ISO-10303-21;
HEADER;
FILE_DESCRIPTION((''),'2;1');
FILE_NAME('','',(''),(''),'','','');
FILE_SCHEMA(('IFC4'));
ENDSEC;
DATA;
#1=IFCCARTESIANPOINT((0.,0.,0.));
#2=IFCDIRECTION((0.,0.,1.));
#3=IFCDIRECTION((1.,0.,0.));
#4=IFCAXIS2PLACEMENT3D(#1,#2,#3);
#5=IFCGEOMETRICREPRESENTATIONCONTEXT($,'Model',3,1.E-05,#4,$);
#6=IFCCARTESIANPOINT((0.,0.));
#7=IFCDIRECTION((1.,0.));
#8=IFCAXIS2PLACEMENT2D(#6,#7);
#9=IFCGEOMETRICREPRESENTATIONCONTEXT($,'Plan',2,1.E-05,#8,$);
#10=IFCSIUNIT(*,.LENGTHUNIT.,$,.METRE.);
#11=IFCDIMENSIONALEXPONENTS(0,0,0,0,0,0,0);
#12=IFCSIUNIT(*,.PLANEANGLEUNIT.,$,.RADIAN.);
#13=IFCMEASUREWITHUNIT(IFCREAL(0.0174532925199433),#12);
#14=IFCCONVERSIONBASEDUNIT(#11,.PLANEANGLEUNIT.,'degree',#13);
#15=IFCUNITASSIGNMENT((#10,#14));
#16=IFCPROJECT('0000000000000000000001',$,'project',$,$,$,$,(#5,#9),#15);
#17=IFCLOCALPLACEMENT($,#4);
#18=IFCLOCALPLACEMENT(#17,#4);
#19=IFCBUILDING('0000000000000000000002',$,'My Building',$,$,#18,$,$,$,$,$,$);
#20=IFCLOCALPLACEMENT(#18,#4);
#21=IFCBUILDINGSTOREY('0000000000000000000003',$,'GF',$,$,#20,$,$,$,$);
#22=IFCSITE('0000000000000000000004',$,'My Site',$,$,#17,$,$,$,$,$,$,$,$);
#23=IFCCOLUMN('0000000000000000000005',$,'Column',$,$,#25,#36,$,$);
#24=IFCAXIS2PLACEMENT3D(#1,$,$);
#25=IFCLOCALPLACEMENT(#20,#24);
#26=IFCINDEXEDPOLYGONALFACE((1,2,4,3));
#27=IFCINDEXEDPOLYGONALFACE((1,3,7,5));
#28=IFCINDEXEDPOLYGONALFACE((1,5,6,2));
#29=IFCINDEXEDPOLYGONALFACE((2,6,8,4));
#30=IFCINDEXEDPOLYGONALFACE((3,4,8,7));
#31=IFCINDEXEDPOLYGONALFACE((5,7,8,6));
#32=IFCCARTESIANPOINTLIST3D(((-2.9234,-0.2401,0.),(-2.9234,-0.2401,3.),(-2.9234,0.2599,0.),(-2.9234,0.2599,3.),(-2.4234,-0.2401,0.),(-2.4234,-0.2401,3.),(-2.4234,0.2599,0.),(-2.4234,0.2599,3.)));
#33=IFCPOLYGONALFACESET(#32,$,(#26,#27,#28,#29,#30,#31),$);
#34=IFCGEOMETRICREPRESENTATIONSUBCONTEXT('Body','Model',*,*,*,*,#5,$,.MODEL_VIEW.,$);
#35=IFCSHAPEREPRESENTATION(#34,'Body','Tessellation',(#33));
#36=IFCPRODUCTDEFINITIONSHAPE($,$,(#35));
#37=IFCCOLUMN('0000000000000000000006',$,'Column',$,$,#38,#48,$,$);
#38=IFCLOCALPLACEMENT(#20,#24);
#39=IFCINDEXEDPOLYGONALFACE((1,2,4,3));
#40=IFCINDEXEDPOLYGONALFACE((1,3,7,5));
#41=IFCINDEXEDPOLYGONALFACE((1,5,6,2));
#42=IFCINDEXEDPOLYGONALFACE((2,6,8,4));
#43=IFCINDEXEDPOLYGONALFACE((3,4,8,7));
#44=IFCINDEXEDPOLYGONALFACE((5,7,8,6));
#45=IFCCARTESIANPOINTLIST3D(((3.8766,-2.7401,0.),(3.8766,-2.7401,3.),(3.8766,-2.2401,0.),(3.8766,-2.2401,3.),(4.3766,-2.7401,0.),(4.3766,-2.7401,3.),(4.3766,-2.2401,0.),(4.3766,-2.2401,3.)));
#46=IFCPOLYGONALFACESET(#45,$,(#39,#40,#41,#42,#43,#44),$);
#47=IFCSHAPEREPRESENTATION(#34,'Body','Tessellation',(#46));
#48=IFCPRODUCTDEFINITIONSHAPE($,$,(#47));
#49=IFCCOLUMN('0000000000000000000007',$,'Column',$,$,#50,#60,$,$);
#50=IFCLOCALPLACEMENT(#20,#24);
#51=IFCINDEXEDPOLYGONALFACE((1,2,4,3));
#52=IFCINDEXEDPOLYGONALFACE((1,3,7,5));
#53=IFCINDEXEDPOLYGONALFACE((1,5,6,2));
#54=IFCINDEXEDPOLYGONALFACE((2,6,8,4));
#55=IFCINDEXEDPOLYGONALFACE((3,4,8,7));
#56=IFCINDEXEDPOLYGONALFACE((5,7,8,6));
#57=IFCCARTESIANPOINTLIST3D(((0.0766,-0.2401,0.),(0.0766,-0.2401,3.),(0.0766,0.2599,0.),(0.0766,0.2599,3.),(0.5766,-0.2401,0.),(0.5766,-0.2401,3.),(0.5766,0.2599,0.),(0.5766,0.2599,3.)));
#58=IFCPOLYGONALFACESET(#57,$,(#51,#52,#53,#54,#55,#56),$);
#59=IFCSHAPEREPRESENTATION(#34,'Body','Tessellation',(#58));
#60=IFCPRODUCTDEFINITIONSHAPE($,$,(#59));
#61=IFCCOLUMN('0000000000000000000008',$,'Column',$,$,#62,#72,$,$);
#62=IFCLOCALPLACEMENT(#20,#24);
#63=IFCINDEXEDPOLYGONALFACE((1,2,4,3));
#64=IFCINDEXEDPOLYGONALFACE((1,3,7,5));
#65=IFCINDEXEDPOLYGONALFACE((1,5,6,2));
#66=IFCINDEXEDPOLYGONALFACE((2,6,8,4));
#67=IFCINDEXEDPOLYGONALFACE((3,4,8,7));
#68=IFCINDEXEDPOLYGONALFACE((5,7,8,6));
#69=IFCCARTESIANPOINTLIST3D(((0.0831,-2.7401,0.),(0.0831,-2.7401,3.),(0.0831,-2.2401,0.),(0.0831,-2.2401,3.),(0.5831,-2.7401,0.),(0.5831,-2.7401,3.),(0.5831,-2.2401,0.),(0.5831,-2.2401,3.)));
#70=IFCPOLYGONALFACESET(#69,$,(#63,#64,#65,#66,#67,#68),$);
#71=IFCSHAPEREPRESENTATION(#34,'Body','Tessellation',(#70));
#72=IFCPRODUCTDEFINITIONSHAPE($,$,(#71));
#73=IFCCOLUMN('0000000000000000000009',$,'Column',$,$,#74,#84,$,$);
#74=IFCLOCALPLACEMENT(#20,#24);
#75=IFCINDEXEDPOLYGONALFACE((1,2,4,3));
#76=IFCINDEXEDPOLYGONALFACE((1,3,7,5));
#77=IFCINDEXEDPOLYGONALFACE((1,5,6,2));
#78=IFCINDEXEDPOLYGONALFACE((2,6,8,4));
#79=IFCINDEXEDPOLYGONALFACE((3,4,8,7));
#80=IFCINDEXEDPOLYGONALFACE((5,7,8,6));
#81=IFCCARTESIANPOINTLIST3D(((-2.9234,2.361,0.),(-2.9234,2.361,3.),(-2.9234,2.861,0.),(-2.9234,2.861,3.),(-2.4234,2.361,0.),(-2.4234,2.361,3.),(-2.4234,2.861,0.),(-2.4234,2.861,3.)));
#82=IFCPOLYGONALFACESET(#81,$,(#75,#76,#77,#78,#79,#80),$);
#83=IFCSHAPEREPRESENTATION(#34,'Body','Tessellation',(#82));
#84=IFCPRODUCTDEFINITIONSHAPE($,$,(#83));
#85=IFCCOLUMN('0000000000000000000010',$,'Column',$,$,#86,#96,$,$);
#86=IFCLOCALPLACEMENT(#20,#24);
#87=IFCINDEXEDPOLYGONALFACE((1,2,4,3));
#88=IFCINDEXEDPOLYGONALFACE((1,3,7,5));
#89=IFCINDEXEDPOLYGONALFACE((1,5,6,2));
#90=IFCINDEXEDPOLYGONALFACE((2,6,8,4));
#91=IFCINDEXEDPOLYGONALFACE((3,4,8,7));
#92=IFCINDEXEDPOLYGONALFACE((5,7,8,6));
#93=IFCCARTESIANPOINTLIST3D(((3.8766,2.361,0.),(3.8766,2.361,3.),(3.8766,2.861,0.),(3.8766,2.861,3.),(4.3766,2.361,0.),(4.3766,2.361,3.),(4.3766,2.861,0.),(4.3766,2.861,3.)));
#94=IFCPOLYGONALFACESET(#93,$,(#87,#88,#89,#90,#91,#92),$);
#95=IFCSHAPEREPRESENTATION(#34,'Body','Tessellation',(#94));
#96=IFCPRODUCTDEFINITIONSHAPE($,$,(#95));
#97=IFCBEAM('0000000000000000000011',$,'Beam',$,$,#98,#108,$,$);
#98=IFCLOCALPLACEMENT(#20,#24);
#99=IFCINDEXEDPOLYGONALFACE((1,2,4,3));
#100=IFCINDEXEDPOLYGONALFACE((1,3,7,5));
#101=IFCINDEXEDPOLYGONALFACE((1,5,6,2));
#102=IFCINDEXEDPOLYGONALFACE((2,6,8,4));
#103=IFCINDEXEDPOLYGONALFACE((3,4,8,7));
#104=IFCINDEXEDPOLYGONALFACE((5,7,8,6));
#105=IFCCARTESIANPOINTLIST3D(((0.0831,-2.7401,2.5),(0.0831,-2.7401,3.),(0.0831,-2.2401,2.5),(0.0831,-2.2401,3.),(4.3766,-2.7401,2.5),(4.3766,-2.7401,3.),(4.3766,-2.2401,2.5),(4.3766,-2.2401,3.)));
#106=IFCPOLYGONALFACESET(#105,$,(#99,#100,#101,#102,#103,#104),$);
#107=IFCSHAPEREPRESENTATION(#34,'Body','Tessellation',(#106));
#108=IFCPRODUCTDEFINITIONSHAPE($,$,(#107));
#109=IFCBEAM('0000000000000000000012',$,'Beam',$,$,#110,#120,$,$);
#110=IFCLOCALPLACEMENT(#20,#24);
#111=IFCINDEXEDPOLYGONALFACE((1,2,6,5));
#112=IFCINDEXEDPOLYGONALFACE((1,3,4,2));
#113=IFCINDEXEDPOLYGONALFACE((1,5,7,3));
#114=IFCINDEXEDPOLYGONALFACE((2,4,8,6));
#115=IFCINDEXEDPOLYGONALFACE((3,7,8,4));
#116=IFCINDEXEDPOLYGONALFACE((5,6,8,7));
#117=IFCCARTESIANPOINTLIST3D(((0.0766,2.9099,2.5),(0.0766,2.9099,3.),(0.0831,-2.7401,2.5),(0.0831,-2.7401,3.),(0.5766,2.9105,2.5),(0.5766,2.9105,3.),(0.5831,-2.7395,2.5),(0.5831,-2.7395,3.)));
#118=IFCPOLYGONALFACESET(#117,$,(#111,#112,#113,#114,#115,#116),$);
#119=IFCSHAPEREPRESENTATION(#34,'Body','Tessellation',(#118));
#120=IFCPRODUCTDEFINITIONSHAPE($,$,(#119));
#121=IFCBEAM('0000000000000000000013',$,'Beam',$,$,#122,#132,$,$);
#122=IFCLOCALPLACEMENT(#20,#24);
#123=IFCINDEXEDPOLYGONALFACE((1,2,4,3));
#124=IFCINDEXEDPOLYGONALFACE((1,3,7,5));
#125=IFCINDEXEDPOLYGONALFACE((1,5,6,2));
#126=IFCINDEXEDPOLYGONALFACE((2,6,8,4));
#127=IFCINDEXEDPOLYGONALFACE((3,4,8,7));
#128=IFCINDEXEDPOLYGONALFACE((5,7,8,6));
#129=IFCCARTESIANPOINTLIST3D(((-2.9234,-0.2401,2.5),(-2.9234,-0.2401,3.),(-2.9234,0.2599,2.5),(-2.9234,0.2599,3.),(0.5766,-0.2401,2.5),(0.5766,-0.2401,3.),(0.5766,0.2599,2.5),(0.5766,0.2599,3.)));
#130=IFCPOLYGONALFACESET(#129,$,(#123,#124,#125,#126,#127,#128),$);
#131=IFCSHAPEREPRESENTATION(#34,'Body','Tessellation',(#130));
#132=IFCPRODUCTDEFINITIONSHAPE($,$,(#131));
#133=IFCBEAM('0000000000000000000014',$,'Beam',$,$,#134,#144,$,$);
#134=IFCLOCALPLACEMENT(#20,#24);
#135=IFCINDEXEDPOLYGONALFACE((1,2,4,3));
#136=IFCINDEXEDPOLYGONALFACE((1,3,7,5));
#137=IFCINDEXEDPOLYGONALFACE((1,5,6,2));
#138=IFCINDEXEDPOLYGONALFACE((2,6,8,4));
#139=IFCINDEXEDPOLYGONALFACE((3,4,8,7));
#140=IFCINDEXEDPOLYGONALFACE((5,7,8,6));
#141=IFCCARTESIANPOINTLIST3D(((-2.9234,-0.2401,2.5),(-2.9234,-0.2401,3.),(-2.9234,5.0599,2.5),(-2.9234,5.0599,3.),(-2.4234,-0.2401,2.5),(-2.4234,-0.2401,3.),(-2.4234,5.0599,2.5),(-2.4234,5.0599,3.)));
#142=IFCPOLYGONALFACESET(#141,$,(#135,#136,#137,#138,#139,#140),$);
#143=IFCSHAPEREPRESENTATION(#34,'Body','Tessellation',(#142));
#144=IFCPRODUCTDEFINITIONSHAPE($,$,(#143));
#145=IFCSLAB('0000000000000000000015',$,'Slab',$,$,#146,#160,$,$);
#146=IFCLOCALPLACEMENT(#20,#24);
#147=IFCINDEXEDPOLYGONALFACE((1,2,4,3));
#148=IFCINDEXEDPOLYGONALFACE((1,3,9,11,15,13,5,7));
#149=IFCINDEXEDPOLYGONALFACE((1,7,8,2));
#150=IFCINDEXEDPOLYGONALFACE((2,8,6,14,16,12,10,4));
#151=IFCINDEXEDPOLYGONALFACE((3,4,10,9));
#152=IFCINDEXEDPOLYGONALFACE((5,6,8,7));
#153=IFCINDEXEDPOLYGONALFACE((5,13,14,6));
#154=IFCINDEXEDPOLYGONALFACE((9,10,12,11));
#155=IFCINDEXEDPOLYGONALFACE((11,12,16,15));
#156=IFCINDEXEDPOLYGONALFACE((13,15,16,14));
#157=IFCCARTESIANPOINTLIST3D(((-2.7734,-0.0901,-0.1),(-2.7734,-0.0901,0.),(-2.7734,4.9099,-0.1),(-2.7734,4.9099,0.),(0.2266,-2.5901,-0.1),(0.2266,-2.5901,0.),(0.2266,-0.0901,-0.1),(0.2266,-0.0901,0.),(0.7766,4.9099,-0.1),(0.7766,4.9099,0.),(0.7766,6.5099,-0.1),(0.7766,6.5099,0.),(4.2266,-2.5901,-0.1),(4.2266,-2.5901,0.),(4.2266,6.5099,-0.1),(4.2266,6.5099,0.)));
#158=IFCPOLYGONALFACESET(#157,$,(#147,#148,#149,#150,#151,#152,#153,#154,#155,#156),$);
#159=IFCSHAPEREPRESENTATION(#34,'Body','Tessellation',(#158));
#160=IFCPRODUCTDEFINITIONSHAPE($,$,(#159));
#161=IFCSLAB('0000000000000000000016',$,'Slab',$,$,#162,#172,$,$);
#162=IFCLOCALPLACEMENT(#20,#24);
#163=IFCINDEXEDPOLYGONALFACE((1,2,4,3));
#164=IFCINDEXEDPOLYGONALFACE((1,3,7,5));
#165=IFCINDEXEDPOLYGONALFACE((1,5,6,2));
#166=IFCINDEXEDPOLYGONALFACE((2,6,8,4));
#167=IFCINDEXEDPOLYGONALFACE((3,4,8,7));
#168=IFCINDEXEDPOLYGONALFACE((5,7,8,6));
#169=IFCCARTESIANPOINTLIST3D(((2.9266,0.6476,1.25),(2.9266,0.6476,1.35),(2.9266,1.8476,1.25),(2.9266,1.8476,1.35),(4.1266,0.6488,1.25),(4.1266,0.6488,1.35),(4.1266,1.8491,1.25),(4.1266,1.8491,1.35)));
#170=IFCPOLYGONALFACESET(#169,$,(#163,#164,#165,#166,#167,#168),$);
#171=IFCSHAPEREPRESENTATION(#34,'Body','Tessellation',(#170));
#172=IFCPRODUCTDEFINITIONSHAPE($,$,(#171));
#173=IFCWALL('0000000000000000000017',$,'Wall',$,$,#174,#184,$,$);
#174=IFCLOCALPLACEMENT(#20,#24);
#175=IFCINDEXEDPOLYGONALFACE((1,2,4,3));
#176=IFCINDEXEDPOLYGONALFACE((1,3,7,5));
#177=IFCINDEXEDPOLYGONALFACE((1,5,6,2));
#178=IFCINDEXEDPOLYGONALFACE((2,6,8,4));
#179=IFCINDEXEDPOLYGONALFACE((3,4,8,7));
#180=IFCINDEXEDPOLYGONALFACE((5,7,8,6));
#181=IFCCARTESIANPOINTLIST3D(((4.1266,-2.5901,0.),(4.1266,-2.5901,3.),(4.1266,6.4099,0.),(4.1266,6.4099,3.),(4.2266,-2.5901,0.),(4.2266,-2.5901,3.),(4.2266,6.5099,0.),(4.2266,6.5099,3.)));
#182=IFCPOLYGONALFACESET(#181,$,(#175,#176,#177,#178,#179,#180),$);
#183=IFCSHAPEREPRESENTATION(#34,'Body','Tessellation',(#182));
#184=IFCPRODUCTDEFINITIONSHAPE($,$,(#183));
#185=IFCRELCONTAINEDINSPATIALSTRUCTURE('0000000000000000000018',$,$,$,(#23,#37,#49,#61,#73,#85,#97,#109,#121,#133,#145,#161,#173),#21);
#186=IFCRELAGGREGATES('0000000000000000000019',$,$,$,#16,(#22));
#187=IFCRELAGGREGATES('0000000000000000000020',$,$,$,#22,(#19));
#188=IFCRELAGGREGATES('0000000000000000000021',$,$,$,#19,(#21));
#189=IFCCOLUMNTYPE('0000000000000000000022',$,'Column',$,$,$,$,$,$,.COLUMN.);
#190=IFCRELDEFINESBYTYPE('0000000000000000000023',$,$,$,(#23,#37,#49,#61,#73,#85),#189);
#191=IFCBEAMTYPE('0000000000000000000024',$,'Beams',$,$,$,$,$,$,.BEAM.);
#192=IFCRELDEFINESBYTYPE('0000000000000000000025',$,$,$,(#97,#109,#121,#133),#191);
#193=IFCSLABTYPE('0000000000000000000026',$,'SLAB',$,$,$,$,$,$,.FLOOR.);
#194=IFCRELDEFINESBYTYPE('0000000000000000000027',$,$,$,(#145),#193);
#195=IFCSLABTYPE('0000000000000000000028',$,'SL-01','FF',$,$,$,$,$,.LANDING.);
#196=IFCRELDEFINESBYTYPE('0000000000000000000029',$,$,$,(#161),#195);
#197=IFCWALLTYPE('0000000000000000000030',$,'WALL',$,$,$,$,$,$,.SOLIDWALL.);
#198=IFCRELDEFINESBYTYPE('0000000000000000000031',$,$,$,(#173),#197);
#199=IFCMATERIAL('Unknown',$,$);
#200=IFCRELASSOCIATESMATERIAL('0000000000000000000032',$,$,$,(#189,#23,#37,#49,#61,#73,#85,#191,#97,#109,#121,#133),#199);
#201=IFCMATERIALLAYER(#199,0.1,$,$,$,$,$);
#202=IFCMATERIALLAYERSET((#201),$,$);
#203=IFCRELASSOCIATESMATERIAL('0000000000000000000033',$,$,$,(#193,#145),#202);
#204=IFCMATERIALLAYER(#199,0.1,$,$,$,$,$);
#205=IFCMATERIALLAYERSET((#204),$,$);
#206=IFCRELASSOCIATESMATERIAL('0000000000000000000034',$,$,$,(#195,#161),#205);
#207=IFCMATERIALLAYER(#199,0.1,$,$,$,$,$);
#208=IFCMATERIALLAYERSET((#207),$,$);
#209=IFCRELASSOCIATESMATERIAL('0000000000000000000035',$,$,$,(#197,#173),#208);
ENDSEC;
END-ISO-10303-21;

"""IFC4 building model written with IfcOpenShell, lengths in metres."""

from ifc_helpers import new_model, entity, si_unit, converted_unit, frame, origin_with_axes, origin_2d_with_axis, place, context, subcontext, project, spatial, line, indexed_curve, rectangle, outline, extrude, material, layer, layer_set, layer_usage, material_profile, profile_set, profile_usage, type_object, element, save


model = new_model("IFC4")

# Units and contexts
model_context = context("Model", 3, precision=1e-05, world=origin_with_axes())
plan_context = context("Plan", 2, precision=1e-05, world=origin_2d_with_axis())
body_context_1 = subcontext(model_context, "Body", "Model", "MODEL_VIEW")
ifc_project = project(units=[si_unit("LENGTHUNIT", "METRE"), converted_unit("PLANEANGLEUNIT", "degree", entity("IfcReal", 0.0174532925199433), si_unit("PLANEANGLEUNIT", "RADIAN"), dimensions=[0, 0, 0, 0, 0, 0, 0])], contexts=[model_context, plan_context])

# Site, building, storey
site_placement = place(None, origin_with_axes())
site = spatial("IfcSite", under=ifc_project, at=site_placement, Name="My Site")
building_placement = place(site_placement, origin_with_axes())
building = spatial("IfcBuilding", under=site, at=building_placement, Name="My Building")
storey_placement = place(building_placement, origin_with_axes())
storey = spatial("IfcBuildingStorey", under=building, at=storey_placement, Name="GF")

# Columns
ifc_material_1 = material(Name="Unknown")
ifc_material_profile_1 = material_profile(ifc_material_1, rectangle(XDim=0.5, YDim=0.5))
ifc_profile_set_1 = profile_set([ifc_material_profile_1])
ifc_profile_usage_1 = profile_usage(ifc_profile_set_1, cardinal=5)
column_type = type_object("IfcColumnType", Name="Column", PredefinedType="COLUMN", material=ifc_profile_set_1)
column_1_placement = place(storey_placement, frame((-2.6734, 0.0099, 0.0), z_axis=(0.0, 0.0, 1.0), x_axis=(1.0, 0.0, 0.0)))
element("IfcColumn", 1, at=column_1_placement, inside=storey, type_object=column_type, material=ifc_profile_usage_1, Name="Column", context=body_context_1, shape_type="SweptSolid", body=[
    extrude(rectangle(XDim=0.5, YDim=0.5), origin_with_axes(), (0.0, 0.0, 1.0), 3.0),
])
ifc_profile_usage_2 = profile_usage(ifc_profile_set_1, cardinal=5)
column_2_placement = place(storey_placement, frame((4.1266, -2.4901, 0.0), z_axis=(0.0, 0.0, 1.0), x_axis=(1.0, 0.0, 0.0)))
element("IfcColumn", 2, at=column_2_placement, inside=storey, type_object=column_type, material=ifc_profile_usage_2, Name="Column", context=body_context_1, shape_type="SweptSolid", body=[
    extrude(rectangle(XDim=0.5, YDim=0.5), origin_with_axes(), (0.0, 0.0, 1.0), 3.0),
])
ifc_profile_usage_3 = profile_usage(ifc_profile_set_1, cardinal=5)
column_3_placement = place(storey_placement, frame((0.3266, 0.0099, 0.0), z_axis=(0.0, 0.0, 1.0), x_axis=(1.0, 0.0, 0.0)))
element("IfcColumn", 3, at=column_3_placement, inside=storey, type_object=column_type, material=ifc_profile_usage_3, Name="Column", context=body_context_1, shape_type="SweptSolid", body=[
    extrude(rectangle(XDim=0.5, YDim=0.5), origin_with_axes(), (0.0, 0.0, 1.0), 3.0),
])
ifc_profile_usage_4 = profile_usage(ifc_profile_set_1, cardinal=5)
column_4_placement = place(storey_placement, frame((0.3331, -2.4901, 0.0), z_axis=(0.0, 0.0, 1.0), x_axis=(1.0, 0.0, 0.0)))
element("IfcColumn", 4, at=column_4_placement, inside=storey, type_object=column_type, material=ifc_profile_usage_4, Name="Column", context=body_context_1, shape_type="SweptSolid", body=[
    extrude(rectangle(XDim=0.5, YDim=0.5), origin_with_axes(), (0.0, 0.0, 1.0), 3.0),
])
ifc_profile_usage_5 = profile_usage(ifc_profile_set_1, cardinal=5)
column_5_placement = place(storey_placement, frame((-2.6734, 2.611, 0.0), z_axis=(0.0, 0.0, 1.0), x_axis=(1.0, 0.0, 0.0)))
element("IfcColumn", 5, at=column_5_placement, inside=storey, type_object=column_type, material=ifc_profile_usage_5, Name="Column", context=body_context_1, shape_type="SweptSolid", body=[
    extrude(rectangle(XDim=0.5, YDim=0.5), origin_with_axes(), (0.0, 0.0, 1.0), 3.0),
])
ifc_profile_usage_6 = profile_usage(ifc_profile_set_1, cardinal=5)
column_6_placement = place(storey_placement, frame((4.1266, 2.611, 0.0), z_axis=(0.0, 0.0, 1.0), x_axis=(1.0, 0.0, 0.0)))
element("IfcColumn", 6, at=column_6_placement, inside=storey, type_object=column_type, material=ifc_profile_usage_6, Name="Column", context=body_context_1, shape_type="SweptSolid", body=[
    extrude(rectangle(XDim=0.5, YDim=0.5), origin_with_axes(), (0.0, 0.0, 1.0), 3.0),
])

# Beams
ifc_material_profile_2 = material_profile(ifc_material_1, rectangle(XDim=0.5, YDim=0.5))
ifc_profile_set_2 = profile_set([ifc_material_profile_2])
ifc_profile_usage_7 = profile_usage(ifc_profile_set_2, cardinal=7)
beam_type = type_object("IfcBeamType", Name="Beams", PredefinedType="BEAM", material=ifc_profile_set_2)
beam_1_placement = place(storey_placement, frame((4.3766, -2.7401, 3.0), z_axis=(-1.0, 0.0, 0.0), x_axis=(0.0, -1.0, 0.0)))
element("IfcBeam", 7, at=beam_1_placement, inside=storey, type_object=beam_type, material=ifc_profile_usage_7, Name="Beam", context=body_context_1, shape_type="SweptSolid", body=[
    extrude(rectangle(XDim=0.5, YDim=0.5), frame((-0.25, -0.25, 0.0), z_axis=(0.0, 0.0, 1.0), x_axis=(1.0, 0.0, 0.0)), (0.0, 0.0, 1.0), 4.2935),
])
ifc_profile_usage_8 = profile_usage(ifc_profile_set_2, cardinal=7)
beam_2_placement = place(storey_placement, frame((0.0831, -2.7401, 3.0), z_axis=(-0.001142, 0.999999, 0.0), x_axis=(-0.999999, -0.001142, 0.0)))
element("IfcBeam", 8, at=beam_2_placement, inside=storey, type_object=beam_type, material=ifc_profile_usage_8, Name="Beam", context=body_context_1, shape_type="SweptSolid", body=[
    extrude(rectangle(XDim=0.5, YDim=0.5), frame((-0.25, -0.25, 0.0), z_axis=(0.0, 0.0, 1.0), x_axis=(1.0, 0.0, 0.0)), (0.0, 0.0, 1.0), 5.65),
])
ifc_profile_usage_9 = profile_usage(ifc_profile_set_2, cardinal=7)
beam_3_placement = place(storey_placement, frame((0.5766, -0.2401, 3.0), z_axis=(-1.0, 0.0, 0.0), x_axis=(0.0, -1.0, 0.0)))
element("IfcBeam", 9, at=beam_3_placement, inside=storey, type_object=beam_type, material=ifc_profile_usage_9, Name="Beam", context=body_context_1, shape_type="SweptSolid", body=[
    extrude(rectangle(XDim=0.5, YDim=0.5), frame((-0.25, -0.25, 0.0), z_axis=(0.0, 0.0, 1.0), x_axis=(1.0, 0.0, 0.0)), (0.0, 0.0, 1.0), 3.5),
])
ifc_profile_usage_10 = profile_usage(ifc_profile_set_2, cardinal=7)
beam_4_placement = place(storey_placement, frame((-2.9234, -0.2401, 3.0), z_axis=(0.0, 1.0, 0.0), x_axis=(-1.0, 0.0, 0.0)))
element("IfcBeam", 10, at=beam_4_placement, inside=storey, type_object=beam_type, material=ifc_profile_usage_10, Name="Beam", context=body_context_1, shape_type="SweptSolid", body=[
    extrude(rectangle(XDim=0.5, YDim=0.5), frame((-0.25, -0.25, 0.0), z_axis=(0.0, 0.0, 1.0), x_axis=(1.0, 0.0, 0.0)), (0.0, 0.0, 1.0), 5.3),
])

# Slabs
ifc_layer_1 = layer(ifc_material_1, 0.1)
ifc_layer_set_1 = layer_set([ifc_layer_1])
ifc_layer_usage_1 = layer_usage(ifc_layer_set_1, "AXIS3", "POSITIVE", -0.1)
slab_type_1 = type_object("IfcSlabType", Name="SLAB", PredefinedType="FLOOR", material=ifc_layer_set_1)
slab_1_placement = place(storey_placement, frame((4.2266, -2.5901, 0.0), z_axis=(0.0, 0.0, 1.0), x_axis=(1.0, 0.0, 0.0)))
element("IfcSlab", 11, at=slab_1_placement, inside=storey, type_object=slab_type_1, material=ifc_layer_usage_1, Name="Slab", context=body_context_1, shape_type="SweptSolid", body=[
    extrude(outline(indexed_curve([(0.0, 0.0), (0.0, 9.1), (-3.45, 9.1), (-3.45, 7.5), (-7.0, 7.5), (-7.0, 2.5), (-4.0, 2.5), (-4.0, 0.0), (0.0, 0.0)])), frame((0.0, 0.0, -0.1), z_axis=(0.0, 0.0, 1.0), x_axis=(1.0, 0.0, 0.0)), (0.0, 0.0, 1.0), 0.1),
])
ifc_layer_2 = layer(ifc_material_1, 0.1)
ifc_layer_set_2 = layer_set([ifc_layer_2])
ifc_layer_usage_2 = layer_usage(ifc_layer_set_2, "AXIS3", "POSITIVE", -0.1)
slab_type_2 = type_object("IfcSlabType", Name="SL-01", Description="FF", PredefinedType="LANDING", material=ifc_layer_set_2)
slab_2_placement = place(storey_placement, frame((2.9266, 1.8476, 1.35), z_axis=(0.0, 0.0, 1.0), x_axis=(1.0, 0.0, 0.0)))
element("IfcSlab", 12, at=slab_2_placement, inside=storey, type_object=slab_type_2, material=ifc_layer_usage_2, Name="Slab", context=body_context_1, shape_type="SweptSolid", body=[
    extrude(outline(indexed_curve([(0.0, 0.0), (0.0, -1.2), (1.2, -1.1988), (1.2, 0.0014), (0.0, 0.0)])), frame((0.0, 0.0, -0.1), z_axis=(0.0, 0.0, 1.0), x_axis=(1.0, 0.0, 0.0)), (0.0, 0.0, 1.0), 0.1),
])

# Shared definitions
ifc_layer_3 = layer(ifc_material_1, 0.1)
ifc_layer_set_3 = layer_set([ifc_layer_3])
wall_type = type_object("IfcWallType", Name="WALL", PredefinedType="SOLIDWALL", material=ifc_layer_set_3)

# Wall
ifc_layer_usage_3 = layer_usage(ifc_layer_set_3, "AXIS2", "POSITIVE", 0.0)
wall_1_placement = place(storey_placement, frame((4.2266, -2.5901, 0.0), z_axis=(0.0, 0.0, 1.0), x_axis=(0.0, 1.0, 0.0)))
element("IfcWall", 13, at=wall_1_placement, inside=storey, type_object=wall_type, material=ifc_layer_usage_3, Name="Wall", context=body_context_1, shape_type="SweptSolid", body=[
    extrude(outline(indexed_curve([(0.0, 0.0), (0.0, 0.1), (9.0, 0.1), (9.1, 0.0)], segments=[line(1, 2, 3, 4, 1)])), origin_with_axes(), (0.0, 0.0, 1.0), 3.0),
])

save(model, "model.ifc")
